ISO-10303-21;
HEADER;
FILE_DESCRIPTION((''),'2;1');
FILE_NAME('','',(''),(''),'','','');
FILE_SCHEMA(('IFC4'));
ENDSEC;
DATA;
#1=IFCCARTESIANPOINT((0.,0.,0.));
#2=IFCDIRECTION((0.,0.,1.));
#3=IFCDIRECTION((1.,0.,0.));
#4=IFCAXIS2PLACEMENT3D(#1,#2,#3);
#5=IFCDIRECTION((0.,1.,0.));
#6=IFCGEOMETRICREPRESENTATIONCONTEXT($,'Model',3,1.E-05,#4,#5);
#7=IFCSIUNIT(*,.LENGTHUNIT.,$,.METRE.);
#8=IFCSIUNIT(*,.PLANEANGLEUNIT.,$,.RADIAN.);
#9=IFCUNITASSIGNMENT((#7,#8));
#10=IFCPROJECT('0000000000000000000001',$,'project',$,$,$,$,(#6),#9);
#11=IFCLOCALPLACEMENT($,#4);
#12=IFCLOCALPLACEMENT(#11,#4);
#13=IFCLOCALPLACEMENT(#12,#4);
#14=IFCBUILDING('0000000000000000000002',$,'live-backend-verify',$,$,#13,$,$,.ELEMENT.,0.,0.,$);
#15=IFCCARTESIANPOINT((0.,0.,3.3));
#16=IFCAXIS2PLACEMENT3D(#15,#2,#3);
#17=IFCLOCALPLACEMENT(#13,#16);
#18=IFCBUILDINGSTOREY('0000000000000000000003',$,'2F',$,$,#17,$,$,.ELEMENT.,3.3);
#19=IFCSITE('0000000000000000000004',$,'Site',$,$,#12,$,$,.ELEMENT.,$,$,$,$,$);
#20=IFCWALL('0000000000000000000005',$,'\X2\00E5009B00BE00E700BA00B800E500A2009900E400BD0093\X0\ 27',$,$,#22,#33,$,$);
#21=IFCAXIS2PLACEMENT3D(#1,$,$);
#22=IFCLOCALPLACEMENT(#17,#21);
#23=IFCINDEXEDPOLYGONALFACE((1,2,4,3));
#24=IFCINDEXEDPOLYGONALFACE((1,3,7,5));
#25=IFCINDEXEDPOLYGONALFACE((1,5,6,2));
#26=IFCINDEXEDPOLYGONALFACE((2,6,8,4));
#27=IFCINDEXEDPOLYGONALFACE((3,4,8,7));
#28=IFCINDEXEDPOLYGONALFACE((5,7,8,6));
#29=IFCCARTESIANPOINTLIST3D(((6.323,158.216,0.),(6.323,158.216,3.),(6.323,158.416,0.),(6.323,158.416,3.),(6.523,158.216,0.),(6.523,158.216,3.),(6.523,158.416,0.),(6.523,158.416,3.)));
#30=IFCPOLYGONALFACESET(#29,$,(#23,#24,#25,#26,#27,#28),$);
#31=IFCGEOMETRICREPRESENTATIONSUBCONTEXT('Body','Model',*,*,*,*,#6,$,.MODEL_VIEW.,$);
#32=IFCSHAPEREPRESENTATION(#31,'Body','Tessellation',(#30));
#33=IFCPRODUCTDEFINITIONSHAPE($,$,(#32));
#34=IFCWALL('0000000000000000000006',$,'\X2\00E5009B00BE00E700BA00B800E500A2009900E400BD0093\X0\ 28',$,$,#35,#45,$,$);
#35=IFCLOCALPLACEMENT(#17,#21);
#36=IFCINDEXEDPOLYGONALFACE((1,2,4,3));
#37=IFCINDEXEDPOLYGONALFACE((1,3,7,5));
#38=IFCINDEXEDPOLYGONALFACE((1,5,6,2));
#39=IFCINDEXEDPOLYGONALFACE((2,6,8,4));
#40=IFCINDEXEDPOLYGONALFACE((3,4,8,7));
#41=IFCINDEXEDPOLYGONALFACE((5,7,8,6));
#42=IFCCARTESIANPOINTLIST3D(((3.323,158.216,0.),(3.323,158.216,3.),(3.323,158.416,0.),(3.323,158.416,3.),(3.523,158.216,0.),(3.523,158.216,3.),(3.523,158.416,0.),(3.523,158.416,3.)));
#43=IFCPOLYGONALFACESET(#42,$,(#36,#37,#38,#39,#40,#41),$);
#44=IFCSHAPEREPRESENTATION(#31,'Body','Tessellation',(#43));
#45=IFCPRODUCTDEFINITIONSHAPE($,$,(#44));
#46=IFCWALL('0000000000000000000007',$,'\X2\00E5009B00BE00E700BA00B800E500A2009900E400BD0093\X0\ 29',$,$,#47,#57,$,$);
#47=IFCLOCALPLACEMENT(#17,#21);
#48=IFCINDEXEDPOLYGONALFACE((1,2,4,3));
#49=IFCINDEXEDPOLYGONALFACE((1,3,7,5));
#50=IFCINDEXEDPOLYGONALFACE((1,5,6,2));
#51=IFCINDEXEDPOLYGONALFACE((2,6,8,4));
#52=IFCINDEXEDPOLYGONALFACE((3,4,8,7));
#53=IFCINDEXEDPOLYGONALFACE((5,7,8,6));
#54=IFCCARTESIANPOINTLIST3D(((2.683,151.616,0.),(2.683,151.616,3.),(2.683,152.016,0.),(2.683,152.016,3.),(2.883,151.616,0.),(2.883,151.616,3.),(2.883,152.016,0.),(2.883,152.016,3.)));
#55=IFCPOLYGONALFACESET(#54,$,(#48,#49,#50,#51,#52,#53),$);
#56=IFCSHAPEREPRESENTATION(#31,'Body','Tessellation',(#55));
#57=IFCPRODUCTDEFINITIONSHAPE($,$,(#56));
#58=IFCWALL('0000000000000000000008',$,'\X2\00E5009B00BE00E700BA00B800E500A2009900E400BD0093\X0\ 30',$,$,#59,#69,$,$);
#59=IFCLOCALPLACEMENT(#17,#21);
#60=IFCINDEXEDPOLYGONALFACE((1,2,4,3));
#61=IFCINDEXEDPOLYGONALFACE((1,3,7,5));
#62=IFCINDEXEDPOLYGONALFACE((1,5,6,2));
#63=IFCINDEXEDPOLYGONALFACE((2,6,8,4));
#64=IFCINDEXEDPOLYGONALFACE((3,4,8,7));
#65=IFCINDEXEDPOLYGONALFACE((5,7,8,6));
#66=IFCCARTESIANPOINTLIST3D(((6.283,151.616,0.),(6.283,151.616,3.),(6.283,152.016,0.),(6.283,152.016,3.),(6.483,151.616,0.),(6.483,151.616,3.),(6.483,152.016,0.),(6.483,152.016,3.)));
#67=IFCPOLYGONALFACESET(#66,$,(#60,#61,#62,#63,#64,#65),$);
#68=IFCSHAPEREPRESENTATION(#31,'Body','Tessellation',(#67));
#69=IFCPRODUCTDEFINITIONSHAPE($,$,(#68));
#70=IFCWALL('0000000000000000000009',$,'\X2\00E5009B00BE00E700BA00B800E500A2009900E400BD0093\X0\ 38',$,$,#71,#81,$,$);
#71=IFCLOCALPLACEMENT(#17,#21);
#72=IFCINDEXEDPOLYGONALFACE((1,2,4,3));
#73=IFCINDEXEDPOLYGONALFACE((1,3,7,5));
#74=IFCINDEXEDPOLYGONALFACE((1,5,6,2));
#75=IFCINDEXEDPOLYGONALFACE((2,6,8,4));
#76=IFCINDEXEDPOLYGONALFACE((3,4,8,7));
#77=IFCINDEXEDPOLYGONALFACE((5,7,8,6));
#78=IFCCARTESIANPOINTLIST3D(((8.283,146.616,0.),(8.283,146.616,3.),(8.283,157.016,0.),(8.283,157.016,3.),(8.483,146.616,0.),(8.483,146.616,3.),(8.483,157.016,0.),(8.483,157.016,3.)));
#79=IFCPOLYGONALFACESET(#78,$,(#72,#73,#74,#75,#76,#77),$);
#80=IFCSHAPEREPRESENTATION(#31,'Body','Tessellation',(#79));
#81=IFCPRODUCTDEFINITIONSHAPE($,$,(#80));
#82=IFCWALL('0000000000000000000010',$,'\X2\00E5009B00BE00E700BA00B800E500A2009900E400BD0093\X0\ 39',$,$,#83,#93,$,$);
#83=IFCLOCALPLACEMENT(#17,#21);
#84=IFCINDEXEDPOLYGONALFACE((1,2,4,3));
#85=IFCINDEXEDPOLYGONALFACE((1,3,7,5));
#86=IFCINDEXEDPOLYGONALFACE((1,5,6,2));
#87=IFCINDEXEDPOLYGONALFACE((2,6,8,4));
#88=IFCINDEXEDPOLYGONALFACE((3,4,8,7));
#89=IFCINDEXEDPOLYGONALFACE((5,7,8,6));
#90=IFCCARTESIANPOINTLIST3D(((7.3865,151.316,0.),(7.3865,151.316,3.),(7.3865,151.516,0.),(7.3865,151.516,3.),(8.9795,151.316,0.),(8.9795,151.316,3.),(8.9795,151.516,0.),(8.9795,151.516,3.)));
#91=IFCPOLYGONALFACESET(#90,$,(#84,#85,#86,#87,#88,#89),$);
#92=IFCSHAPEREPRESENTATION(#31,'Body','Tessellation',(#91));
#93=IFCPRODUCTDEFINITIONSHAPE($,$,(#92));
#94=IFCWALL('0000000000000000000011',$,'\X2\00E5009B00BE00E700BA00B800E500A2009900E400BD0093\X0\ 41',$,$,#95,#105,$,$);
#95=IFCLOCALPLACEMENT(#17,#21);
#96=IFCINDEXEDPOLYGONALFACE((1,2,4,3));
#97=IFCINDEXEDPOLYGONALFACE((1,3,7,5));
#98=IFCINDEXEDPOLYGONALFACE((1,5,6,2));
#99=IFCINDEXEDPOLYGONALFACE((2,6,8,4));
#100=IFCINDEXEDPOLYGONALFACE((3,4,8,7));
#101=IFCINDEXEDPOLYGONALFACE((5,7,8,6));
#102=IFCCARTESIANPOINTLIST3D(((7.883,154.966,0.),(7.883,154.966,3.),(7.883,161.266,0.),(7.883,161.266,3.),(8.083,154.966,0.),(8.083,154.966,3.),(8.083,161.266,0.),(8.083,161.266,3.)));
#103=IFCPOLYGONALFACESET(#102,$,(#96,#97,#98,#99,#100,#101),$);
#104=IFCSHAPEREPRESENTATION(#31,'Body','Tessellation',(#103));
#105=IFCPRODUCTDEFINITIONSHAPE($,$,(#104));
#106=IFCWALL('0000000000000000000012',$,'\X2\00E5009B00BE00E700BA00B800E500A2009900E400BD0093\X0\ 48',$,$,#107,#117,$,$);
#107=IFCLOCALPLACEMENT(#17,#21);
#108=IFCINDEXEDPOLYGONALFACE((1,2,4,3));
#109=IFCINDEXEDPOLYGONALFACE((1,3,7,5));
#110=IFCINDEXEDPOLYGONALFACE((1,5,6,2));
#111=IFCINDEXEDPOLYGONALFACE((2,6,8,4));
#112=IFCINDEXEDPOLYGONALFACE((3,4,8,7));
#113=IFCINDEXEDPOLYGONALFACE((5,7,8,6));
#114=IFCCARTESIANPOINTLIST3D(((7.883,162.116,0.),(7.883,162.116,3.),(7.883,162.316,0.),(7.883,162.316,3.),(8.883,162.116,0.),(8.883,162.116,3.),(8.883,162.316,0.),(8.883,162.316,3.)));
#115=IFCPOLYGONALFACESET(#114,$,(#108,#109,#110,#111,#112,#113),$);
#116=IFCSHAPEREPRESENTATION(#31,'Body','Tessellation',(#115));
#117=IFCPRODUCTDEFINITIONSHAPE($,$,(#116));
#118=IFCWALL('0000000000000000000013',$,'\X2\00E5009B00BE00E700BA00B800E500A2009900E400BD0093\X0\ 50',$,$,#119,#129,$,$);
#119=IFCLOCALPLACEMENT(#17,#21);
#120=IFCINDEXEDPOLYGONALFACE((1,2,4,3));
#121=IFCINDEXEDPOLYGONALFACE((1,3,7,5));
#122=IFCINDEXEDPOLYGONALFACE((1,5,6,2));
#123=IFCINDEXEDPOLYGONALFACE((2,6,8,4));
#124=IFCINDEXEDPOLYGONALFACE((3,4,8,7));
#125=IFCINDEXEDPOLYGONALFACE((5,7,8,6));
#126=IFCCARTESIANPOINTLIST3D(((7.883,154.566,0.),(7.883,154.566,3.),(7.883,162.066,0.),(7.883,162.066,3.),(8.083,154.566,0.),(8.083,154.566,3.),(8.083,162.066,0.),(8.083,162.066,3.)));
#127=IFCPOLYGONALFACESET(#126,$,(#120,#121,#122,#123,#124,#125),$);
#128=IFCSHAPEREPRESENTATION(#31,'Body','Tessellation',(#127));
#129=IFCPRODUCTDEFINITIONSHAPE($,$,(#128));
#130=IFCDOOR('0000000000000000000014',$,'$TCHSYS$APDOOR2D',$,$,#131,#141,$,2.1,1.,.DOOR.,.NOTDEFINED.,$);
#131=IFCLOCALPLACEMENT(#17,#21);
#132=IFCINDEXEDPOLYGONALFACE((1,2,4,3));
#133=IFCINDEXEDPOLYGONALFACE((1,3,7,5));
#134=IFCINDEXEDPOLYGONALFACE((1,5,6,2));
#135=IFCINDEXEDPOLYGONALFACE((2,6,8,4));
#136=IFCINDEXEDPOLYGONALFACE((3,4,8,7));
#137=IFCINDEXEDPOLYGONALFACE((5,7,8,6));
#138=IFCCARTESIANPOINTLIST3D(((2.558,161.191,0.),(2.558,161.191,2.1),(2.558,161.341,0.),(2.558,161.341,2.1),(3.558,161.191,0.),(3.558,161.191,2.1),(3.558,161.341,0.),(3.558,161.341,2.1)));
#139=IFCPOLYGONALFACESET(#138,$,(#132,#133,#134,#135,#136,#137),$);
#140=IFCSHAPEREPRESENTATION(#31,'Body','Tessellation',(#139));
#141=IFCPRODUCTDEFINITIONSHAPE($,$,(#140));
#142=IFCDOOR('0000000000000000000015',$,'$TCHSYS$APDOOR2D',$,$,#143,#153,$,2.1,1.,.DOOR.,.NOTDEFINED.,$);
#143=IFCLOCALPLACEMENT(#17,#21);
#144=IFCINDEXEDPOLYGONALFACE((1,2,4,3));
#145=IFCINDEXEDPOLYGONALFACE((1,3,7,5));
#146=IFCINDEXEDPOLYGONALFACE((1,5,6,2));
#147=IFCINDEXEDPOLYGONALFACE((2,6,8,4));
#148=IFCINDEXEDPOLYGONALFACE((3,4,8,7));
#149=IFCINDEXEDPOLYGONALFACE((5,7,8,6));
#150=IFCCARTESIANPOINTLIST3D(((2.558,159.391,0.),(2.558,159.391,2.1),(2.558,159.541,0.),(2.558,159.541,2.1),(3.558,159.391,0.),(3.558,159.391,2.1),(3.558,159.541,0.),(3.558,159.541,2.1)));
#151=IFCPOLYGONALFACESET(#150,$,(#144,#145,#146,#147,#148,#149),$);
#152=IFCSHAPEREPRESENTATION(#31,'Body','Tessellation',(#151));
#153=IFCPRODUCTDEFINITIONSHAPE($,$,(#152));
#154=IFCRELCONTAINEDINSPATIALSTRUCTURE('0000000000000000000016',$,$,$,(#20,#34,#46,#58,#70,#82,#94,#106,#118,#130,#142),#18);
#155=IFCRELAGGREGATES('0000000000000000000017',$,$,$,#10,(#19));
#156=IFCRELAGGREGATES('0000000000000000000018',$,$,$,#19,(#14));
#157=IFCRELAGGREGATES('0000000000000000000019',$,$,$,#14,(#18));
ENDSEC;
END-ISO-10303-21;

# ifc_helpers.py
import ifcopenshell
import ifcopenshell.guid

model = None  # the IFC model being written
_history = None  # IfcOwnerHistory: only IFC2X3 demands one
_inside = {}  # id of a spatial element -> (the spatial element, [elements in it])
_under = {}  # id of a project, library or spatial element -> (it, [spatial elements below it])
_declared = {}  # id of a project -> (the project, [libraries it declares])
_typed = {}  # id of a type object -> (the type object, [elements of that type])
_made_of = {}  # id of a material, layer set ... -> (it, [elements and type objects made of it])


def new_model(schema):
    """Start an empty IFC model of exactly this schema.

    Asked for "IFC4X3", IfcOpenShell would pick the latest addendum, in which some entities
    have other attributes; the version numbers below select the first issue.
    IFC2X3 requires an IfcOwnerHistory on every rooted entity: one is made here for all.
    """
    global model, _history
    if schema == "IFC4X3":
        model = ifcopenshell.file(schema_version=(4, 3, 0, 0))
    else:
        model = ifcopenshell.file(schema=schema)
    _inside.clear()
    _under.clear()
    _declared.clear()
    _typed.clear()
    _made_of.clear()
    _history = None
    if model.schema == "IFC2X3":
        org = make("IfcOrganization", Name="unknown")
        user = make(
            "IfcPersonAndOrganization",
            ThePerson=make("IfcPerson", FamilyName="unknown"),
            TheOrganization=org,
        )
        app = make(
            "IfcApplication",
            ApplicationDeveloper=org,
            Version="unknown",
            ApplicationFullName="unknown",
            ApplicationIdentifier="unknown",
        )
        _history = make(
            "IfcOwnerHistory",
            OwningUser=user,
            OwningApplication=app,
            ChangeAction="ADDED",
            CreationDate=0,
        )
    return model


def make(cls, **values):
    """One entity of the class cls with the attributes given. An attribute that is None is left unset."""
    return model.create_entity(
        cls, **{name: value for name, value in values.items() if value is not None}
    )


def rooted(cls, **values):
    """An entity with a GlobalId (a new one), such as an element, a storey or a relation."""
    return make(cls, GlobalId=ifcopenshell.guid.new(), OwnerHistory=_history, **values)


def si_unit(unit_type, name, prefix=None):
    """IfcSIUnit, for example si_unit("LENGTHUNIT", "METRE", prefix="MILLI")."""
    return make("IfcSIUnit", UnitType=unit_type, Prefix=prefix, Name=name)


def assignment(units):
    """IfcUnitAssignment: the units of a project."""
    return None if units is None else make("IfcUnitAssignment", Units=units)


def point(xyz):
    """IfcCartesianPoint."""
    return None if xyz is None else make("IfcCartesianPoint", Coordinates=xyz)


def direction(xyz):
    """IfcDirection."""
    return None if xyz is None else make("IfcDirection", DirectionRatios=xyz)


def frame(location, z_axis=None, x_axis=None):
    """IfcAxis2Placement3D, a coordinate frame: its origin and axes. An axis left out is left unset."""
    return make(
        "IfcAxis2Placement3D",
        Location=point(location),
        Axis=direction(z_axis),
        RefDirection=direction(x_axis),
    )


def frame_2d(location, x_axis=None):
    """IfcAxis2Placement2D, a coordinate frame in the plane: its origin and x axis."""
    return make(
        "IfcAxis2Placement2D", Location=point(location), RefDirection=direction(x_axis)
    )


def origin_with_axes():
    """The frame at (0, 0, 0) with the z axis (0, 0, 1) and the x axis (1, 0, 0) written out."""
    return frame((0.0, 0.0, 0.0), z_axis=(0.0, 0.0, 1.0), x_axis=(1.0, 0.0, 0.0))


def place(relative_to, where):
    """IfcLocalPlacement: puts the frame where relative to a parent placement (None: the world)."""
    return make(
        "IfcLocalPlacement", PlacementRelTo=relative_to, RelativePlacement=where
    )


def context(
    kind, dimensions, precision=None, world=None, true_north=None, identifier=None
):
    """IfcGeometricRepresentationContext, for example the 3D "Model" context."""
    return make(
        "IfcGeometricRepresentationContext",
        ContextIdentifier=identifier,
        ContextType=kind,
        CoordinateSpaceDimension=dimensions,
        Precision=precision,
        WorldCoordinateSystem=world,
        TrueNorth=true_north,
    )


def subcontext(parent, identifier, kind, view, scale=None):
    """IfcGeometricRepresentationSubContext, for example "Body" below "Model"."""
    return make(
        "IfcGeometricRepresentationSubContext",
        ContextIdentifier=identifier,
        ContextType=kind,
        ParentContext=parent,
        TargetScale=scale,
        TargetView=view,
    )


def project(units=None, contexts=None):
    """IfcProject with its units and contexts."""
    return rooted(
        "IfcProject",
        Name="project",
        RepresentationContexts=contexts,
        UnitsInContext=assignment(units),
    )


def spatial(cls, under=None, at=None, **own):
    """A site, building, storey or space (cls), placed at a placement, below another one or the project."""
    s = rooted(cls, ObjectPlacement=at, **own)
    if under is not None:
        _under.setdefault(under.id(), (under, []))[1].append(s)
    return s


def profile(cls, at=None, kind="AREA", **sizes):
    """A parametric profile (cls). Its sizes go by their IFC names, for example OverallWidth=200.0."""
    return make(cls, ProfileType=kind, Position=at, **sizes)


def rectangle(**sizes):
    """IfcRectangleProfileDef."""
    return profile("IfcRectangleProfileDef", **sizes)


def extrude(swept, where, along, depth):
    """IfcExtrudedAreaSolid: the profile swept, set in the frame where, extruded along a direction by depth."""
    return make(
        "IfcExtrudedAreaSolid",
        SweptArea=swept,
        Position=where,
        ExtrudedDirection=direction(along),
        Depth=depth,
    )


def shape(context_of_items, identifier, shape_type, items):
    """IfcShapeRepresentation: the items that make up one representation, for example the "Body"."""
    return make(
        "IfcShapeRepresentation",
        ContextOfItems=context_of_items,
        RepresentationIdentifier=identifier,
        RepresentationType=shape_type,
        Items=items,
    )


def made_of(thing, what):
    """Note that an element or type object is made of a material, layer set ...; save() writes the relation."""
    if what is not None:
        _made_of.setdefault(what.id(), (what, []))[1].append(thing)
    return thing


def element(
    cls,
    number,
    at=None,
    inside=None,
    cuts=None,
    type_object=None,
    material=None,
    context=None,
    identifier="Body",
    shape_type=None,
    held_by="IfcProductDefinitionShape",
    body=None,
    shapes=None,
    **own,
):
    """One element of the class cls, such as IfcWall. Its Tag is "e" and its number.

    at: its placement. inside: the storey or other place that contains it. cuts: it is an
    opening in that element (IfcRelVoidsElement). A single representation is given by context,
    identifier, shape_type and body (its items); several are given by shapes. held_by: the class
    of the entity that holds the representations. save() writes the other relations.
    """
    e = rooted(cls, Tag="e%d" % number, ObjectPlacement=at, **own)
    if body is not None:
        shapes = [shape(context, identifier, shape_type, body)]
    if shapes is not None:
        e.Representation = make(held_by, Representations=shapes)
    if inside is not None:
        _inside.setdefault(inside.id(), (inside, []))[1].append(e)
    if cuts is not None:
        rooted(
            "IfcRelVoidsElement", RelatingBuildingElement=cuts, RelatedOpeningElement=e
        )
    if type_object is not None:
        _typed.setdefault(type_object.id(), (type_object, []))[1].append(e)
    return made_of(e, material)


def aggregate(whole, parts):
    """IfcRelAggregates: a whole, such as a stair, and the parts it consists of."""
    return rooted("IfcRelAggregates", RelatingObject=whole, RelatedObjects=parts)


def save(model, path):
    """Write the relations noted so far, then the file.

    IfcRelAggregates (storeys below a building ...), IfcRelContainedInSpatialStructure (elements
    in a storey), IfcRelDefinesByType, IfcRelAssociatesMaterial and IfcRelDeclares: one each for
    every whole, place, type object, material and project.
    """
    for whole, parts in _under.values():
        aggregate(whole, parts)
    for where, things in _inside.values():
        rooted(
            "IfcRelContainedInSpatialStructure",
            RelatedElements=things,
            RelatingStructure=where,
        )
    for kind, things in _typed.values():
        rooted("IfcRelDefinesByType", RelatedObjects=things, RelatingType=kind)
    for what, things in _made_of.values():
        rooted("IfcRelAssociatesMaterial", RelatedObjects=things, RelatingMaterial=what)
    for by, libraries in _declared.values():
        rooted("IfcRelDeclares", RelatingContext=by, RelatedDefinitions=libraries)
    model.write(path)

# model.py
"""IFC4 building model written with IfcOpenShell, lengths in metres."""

from ifc_helpers import new_model, si_unit, direction, frame, frame_2d, origin_with_axes, place, context, subcontext, project, spatial, rectangle, extrude, element, save


model = new_model("IFC4")

# Units and contexts
model_context = context("Model", 3, precision=1e-05, world=origin_with_axes(), true_north=direction((0.0, 1.0, 0.0)))
body_context = subcontext(model_context, "Body", "Model", "MODEL_VIEW")
ifc_project = project(units=[si_unit("LENGTHUNIT", "METRE"), si_unit("PLANEANGLEUNIT", "RADIAN")], contexts=[model_context])

# Site, building, storey
placement = place(None, origin_with_axes())
site_placement = place(placement, origin_with_axes())
site = spatial("IfcSite", under=ifc_project, at=site_placement, Name="Site", CompositionType="ELEMENT")
building_placement = place(site_placement, origin_with_axes())
building = spatial("IfcBuilding", under=site, at=building_placement, Name="live-backend-verify", CompositionType="ELEMENT", ElevationOfRefHeight=0.0, ElevationOfTerrain=0.0)
storey_placement = place(building_placement, frame((0.0, 0.0, 3.3), z_axis=(0.0, 0.0, 1.0), x_axis=(1.0, 0.0, 0.0)))
storey = spatial("IfcBuildingStorey", under=building, at=storey_placement, Name="2F", CompositionType="ELEMENT", Elevation=3.3)

# Walls
for number, where, z_axis, x_axis, name in (
    (1, (6.423, 158.316, 0.0), (0.0, 0.0, 1.0), (0.0, -1.0, 0.0), "å\u009b¾çº¸å¢\u0099ä½\u0093 27"),
    (2, (3.423, 158.316, 0.0), (0.0, 0.0, 1.0), (0.0, -1.0, 0.0), "å\u009b¾çº¸å¢\u0099ä½\u0093 28"),
):
    element("IfcWall", number, at=place(storey_placement, frame(where, z_axis=z_axis, x_axis=x_axis)), inside=storey, Name=name, context=body_context, shape_type="SweptSolid", body=[
        extrude(rectangle(XDim=0.2, YDim=0.2, at=frame_2d((0.0, 0.0), x_axis=(1.0, 0.0, 0.0))), frame((0.0, 0.0, 0.0), z_axis=(0.0, 0.0, 1.0)), (0.0, 0.0, 1.0), 3.0),
    ])
for number, where, z_axis, x_axis, name in (
    (3, (2.783, 151.816, 0.0), (0.0, 0.0, 1.0), (0.0, -1.0, 0.0), "å\u009b¾çº¸å¢\u0099ä½\u0093 29"),
    (4, (6.383, 151.816, 0.0), (0.0, 0.0, 1.0), (0.0, -1.0, 0.0), "å\u009b¾çº¸å¢\u0099ä½\u0093 30"),
):
    element("IfcWall", number, at=place(storey_placement, frame(where, z_axis=z_axis, x_axis=x_axis)), inside=storey, Name=name, context=body_context, shape_type="SweptSolid", body=[
        extrude(rectangle(XDim=0.4, YDim=0.2, at=frame_2d((0.0, 0.0), x_axis=(1.0, 0.0, 0.0))), frame((0.0, 0.0, 0.0), z_axis=(0.0, 0.0, 1.0)), (0.0, 0.0, 1.0), 3.0),
    ])
wall_1_placement = place(storey_placement, frame((8.383, 151.816, 0.0), z_axis=(0.0, 0.0, 1.0), x_axis=(0.0, 1.0, 0.0)))
element("IfcWall", 5, at=wall_1_placement, inside=storey, Name="å\u009b¾çº¸å¢\u0099ä½\u0093 38", context=body_context, shape_type="SweptSolid", body=[
    extrude(rectangle(XDim=10.4, YDim=0.2, at=frame_2d((0.0, 0.0), x_axis=(1.0, 0.0, 0.0))), frame((0.0, 0.0, 0.0), z_axis=(0.0, 0.0, 1.0)), (0.0, 0.0, 1.0), 3.0),
])
wall_2_placement = place(storey_placement, frame((8.183, 151.416, 0.0), z_axis=(0.0, 0.0, 1.0), x_axis=(1.0, 0.0, 0.0)))
element("IfcWall", 6, at=wall_2_placement, inside=storey, Name="å\u009b¾çº¸å¢\u0099ä½\u0093 39", context=body_context, shape_type="SweptSolid", body=[
    extrude(rectangle(XDim=1.593, YDim=0.2, at=frame_2d((0.0, 0.0), x_axis=(1.0, 0.0, 0.0))), frame((0.0, 0.0, 0.0), z_axis=(0.0, 0.0, 1.0)), (0.0, 0.0, 1.0), 3.0),
])
wall_3_placement = place(storey_placement, frame((7.983, 158.116, 0.0), z_axis=(0.0, 0.0, 1.0), x_axis=(0.0, -1.0, 0.0)))
element("IfcWall", 7, at=wall_3_placement, inside=storey, Name="å\u009b¾çº¸å¢\u0099ä½\u0093 41", context=body_context, shape_type="SweptSolid", body=[
    extrude(rectangle(XDim=6.3, YDim=0.2, at=frame_2d((0.0, 0.0), x_axis=(1.0, 0.0, 0.0))), frame((0.0, 0.0, 0.0), z_axis=(0.0, 0.0, 1.0)), (0.0, 0.0, 1.0), 3.0),
])
wall_4_placement = place(storey_placement, frame((8.383, 162.216, 0.0), z_axis=(0.0, 0.0, 1.0), x_axis=(1.0, 0.0, 0.0)))
element("IfcWall", 8, at=wall_4_placement, inside=storey, Name="å\u009b¾çº¸å¢\u0099ä½\u0093 48", context=body_context, shape_type="SweptSolid", body=[
    extrude(rectangle(XDim=1.0, YDim=0.2, at=frame_2d((0.0, 0.0), x_axis=(1.0, 0.0, 0.0))), frame((0.0, 0.0, 0.0), z_axis=(0.0, 0.0, 1.0)), (0.0, 0.0, 1.0), 3.0),
])
wall_5_placement = place(storey_placement, frame((7.983, 158.316, 0.0), z_axis=(0.0, 0.0, 1.0), x_axis=(0.0, 1.0, 0.0)))
element("IfcWall", 9, at=wall_5_placement, inside=storey, Name="å\u009b¾çº¸å¢\u0099ä½\u0093 50", context=body_context, shape_type="SweptSolid", body=[
    extrude(rectangle(XDim=7.5, YDim=0.2, at=frame_2d((0.0, 0.0), x_axis=(1.0, 0.0, 0.0))), frame((0.0, 0.0, 0.0), z_axis=(0.0, 0.0, 1.0)), (0.0, 0.0, 1.0), 3.0),
])

# Doors
for number, where, z_axis, x_axis, name in (
    (10, (3.058, 161.266, 0.0), (0.0, 0.0, 1.0), (1.0, 0.0, 0.0), "$TCHSYS$APDOOR2D"),
    (11, (3.058, 159.466, 0.0), (0.0, 0.0, 1.0), (1.0, 0.0, 0.0), "$TCHSYS$APDOOR2D"),
):
    element("IfcDoor", number, at=place(storey_placement, frame(where, z_axis=z_axis, x_axis=x_axis)), inside=storey, Name=name, OperationType="NOTDEFINED", OverallHeight=2.1, OverallWidth=1.0, PredefinedType="DOOR", context=body_context, shape_type="SweptSolid", body=[
        extrude(rectangle(XDim=1.0, YDim=0.15, at=frame_2d((0.0, 0.0), x_axis=(1.0, 0.0, 0.0))), frame((0.0, 0.0, 0.0), z_axis=(0.0, 0.0, 1.0)), (0.0, 0.0, 1.0), 2.1),
    ])

save(model, "model.ifc")
